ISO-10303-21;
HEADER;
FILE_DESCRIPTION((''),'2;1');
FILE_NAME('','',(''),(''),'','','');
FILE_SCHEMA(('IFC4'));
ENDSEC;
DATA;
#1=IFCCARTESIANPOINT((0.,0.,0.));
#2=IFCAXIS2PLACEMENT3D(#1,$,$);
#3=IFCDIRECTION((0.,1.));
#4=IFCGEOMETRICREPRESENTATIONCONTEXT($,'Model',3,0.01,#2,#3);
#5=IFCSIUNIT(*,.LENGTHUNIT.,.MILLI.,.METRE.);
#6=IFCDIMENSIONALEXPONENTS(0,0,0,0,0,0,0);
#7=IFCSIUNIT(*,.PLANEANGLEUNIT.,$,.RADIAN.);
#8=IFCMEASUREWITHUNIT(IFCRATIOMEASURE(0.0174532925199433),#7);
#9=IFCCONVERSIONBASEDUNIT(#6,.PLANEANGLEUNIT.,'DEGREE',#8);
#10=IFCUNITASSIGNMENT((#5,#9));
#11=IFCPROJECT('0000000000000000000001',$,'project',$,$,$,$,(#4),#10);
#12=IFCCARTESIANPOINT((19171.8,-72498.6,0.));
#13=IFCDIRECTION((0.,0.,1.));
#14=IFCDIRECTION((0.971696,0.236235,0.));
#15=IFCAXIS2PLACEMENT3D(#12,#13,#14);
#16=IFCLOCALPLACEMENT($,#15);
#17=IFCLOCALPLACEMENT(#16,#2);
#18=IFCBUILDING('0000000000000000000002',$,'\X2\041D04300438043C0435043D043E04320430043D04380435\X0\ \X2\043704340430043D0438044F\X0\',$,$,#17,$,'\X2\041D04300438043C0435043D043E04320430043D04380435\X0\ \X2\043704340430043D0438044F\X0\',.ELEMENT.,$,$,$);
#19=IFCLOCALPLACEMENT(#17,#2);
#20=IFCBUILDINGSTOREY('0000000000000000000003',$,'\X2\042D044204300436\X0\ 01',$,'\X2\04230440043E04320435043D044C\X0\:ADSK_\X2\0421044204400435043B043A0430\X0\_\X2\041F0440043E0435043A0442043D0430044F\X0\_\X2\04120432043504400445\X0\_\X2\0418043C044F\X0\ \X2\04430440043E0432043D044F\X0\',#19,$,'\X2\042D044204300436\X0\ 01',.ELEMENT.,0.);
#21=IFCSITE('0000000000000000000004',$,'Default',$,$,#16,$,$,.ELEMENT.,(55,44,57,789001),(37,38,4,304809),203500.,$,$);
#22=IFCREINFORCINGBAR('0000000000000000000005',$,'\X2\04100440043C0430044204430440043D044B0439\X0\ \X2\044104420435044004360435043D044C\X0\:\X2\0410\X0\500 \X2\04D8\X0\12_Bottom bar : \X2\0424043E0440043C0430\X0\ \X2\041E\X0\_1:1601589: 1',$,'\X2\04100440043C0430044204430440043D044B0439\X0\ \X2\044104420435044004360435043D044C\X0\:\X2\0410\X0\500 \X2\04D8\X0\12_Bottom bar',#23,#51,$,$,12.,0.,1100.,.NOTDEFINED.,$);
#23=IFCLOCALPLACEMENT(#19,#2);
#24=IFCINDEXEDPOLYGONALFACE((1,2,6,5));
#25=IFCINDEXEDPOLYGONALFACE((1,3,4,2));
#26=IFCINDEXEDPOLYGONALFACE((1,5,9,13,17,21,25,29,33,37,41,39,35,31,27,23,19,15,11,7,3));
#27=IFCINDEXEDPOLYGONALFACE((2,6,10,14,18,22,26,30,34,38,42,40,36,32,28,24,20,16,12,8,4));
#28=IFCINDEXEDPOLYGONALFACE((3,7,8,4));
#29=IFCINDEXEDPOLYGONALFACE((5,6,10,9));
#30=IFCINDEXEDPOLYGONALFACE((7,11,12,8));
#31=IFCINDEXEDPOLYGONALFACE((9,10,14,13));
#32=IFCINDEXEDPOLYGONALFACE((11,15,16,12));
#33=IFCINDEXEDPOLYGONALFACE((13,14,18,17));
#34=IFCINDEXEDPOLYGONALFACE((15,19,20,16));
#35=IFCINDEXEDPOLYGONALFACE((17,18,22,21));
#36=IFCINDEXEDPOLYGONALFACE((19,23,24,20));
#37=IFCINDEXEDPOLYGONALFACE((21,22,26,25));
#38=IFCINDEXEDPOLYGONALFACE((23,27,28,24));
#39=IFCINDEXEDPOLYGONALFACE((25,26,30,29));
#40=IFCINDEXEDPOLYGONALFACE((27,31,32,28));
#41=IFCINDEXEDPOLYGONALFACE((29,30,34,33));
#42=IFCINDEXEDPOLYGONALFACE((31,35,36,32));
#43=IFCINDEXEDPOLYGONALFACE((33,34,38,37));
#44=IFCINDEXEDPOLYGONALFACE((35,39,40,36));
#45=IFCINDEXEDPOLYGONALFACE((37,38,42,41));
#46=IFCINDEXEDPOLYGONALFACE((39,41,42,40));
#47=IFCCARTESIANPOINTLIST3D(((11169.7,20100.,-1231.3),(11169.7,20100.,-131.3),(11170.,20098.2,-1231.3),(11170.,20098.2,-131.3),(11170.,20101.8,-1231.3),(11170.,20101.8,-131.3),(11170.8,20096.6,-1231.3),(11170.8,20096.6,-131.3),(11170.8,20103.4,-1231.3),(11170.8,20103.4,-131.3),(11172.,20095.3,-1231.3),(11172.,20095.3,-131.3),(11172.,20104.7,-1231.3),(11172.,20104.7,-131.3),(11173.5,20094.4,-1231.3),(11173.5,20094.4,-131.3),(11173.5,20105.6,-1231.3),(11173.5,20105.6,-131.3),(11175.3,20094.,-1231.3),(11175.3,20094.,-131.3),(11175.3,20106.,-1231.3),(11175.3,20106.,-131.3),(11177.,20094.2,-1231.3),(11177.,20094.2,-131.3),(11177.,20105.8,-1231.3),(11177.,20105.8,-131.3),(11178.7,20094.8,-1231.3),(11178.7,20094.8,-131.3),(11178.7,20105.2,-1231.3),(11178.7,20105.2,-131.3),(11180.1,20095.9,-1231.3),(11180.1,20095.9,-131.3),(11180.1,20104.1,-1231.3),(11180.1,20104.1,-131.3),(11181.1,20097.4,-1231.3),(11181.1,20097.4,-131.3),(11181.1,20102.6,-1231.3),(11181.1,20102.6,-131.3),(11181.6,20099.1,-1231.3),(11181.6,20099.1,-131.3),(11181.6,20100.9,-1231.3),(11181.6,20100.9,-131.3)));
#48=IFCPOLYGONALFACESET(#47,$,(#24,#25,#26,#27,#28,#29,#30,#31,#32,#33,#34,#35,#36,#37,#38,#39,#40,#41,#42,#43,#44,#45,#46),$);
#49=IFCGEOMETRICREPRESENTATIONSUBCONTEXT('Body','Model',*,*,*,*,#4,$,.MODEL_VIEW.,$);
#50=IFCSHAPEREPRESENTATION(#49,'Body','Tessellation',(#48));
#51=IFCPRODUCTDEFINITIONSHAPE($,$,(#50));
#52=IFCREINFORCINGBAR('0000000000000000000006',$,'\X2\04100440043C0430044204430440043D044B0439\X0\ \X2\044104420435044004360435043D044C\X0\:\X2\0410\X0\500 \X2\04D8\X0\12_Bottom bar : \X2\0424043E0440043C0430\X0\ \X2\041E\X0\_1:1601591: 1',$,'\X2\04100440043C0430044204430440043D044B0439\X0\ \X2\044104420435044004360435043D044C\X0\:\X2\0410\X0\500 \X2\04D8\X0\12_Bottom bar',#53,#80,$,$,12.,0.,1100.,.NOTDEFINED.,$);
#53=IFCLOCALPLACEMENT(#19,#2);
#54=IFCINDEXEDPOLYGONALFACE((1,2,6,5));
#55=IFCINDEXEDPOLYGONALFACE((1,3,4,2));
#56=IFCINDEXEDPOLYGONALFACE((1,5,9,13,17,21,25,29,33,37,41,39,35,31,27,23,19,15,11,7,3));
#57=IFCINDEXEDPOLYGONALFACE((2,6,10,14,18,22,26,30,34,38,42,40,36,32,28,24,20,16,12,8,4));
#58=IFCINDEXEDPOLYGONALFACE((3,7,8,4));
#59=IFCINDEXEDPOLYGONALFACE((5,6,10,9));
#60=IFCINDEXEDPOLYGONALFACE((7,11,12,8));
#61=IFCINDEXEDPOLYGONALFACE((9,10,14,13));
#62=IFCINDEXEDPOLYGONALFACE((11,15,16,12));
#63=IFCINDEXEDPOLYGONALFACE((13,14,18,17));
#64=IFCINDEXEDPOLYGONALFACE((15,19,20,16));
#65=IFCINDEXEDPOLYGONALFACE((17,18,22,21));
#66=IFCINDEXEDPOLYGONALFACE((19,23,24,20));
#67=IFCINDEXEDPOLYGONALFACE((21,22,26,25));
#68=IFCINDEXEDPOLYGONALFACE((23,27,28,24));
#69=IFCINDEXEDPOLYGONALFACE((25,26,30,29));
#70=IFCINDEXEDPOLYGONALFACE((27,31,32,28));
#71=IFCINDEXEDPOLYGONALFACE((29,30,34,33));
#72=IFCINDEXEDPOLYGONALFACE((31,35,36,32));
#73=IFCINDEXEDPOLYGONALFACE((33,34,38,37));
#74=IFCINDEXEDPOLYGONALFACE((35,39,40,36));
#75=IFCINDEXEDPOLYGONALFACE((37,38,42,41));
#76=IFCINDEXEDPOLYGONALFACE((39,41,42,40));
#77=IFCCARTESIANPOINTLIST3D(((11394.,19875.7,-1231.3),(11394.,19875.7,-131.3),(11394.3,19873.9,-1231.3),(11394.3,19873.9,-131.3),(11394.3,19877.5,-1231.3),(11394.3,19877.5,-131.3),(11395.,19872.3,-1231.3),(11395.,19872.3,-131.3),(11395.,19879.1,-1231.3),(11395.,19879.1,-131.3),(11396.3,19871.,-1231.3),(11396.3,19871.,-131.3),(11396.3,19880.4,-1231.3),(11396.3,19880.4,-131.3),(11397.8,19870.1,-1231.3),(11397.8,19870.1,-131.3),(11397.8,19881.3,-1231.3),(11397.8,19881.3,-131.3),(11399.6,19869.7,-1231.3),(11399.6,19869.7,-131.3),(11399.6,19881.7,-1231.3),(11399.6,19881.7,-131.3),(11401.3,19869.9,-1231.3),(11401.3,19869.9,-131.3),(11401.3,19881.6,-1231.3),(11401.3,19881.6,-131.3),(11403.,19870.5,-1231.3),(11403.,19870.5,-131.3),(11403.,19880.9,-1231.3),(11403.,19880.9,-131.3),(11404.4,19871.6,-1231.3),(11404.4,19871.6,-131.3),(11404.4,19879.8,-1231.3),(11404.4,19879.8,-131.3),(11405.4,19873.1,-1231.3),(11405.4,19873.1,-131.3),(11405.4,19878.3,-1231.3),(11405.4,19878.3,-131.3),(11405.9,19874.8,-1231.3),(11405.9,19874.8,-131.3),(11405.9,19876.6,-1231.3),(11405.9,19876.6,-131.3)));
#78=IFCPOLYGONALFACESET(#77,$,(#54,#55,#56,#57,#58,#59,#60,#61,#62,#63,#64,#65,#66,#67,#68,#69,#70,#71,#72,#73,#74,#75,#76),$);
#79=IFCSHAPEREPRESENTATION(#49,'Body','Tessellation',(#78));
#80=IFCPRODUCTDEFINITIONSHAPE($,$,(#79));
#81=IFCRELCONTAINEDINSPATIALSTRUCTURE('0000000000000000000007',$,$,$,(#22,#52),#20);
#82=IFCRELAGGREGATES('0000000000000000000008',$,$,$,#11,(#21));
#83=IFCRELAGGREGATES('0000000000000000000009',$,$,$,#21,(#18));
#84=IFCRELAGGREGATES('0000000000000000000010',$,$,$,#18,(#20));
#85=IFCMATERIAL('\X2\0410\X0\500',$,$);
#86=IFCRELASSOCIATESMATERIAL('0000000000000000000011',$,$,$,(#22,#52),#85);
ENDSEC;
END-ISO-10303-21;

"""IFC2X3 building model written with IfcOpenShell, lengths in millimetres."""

from ifc_helpers import new_model, entity, si_unit, converted_unit, direction, frame, origin, place, context, subcontext, project, spatial, material, element, save


model = new_model("IFC2X3")

# Units and contexts
model_context = context("Model", 3, precision=0.01, world=origin(), true_north=direction((0.0, 1.0)))
body_context = subcontext(model_context, "Body", "Model", "MODEL_VIEW")
ifc_project = project(units=[si_unit("LENGTHUNIT", "METRE", prefix="MILLI"), converted_unit("PLANEANGLEUNIT", "DEGREE", entity("IfcRatioMeasure", 0.0174532925199433), si_unit("PLANEANGLEUNIT", "RADIAN"), dimensions=[0, 0, 0, 0, 0, 0, 0])], contexts=[model_context])

# Site, building, storey
site_placement = place(None, frame((19171.8, -72498.6, 0.0), z_axis=(0.0, 0.0, 1.0), x_axis=(0.971696, 0.236235, 0.0)))
site = spatial("IfcSite", under=ifc_project, at=site_placement, Name="Default", CompositionType="ELEMENT", RefLatitude=(55, 44, 57, 789001), RefLongitude=(37, 38, 4, 304809), RefElevation=203500.0)
building_placement = place(site_placement, origin())
building = spatial("IfcBuilding", under=site, at=building_placement, Name="Наименование здания", LongName="Наименование здания", CompositionType="ELEMENT")
storey_placement = place(building_placement, origin())
storey = spatial("IfcBuildingStorey", under=building, at=storey_placement, Name="Этаж 01", ObjectType="Уровень:ADSK_Стрелка_Проектная_Вверх_Имя уровня", LongName="Этаж 01", CompositionType="ELEMENT", Elevation=0.0)

# Reinforcing bars
ifc_material = material(Name="А500")
placement = place(storey_placement, origin())
element("IfcReinforcingBar", 1, at=placement, inside=storey, material=ifc_material, Name="Арматурный стержень:А500 Ә12_Bottom bar : Форма О_1:1601589: 1", ObjectType="Арматурный стержень:А500 Ә12_Bottom bar", BarLength=1100.0, BarRole="NOTDEFINED", CrossSectionArea=0.0, NominalDiameter=12.0, context=body_context, shape_type="AdvancedSweptSolid", body=[
    entity("IfcSweptDiskSolid", entity("IfcCompositeCurve", [entity("IfcCompositeCurveSegment", "CONTINUOUS", True, entity("IfcPolyline", [entity("IfcCartesianPoint", [11175.7, 20100.0, -131.3]), entity("IfcCartesianPoint", [11175.7, 20100.0, -1231.3])]))], False), 6.0, None, 0.0, 1.0),
])
element("IfcReinforcingBar", 2, at=placement, inside=storey, material=ifc_material, Name="Арматурный стержень:А500 Ә12_Bottom bar : Форма О_1:1601591: 1", ObjectType="Арматурный стержень:А500 Ә12_Bottom bar", BarLength=1100.0, BarRole="NOTDEFINED", CrossSectionArea=0.0, NominalDiameter=12.0, context=body_context, shape_type="AdvancedSweptSolid", body=[
    entity("IfcSweptDiskSolid", entity("IfcCompositeCurve", [entity("IfcCompositeCurveSegment", "CONTINUOUS", True, entity("IfcPolyline", [entity("IfcCartesianPoint", [11400.0, 19875.7, -131.3]), entity("IfcCartesianPoint", [11400.0, 19875.7, -1231.3])]))], False), 6.0, None, 0.0, 1.0),
])

save(model, "model.ifc")
